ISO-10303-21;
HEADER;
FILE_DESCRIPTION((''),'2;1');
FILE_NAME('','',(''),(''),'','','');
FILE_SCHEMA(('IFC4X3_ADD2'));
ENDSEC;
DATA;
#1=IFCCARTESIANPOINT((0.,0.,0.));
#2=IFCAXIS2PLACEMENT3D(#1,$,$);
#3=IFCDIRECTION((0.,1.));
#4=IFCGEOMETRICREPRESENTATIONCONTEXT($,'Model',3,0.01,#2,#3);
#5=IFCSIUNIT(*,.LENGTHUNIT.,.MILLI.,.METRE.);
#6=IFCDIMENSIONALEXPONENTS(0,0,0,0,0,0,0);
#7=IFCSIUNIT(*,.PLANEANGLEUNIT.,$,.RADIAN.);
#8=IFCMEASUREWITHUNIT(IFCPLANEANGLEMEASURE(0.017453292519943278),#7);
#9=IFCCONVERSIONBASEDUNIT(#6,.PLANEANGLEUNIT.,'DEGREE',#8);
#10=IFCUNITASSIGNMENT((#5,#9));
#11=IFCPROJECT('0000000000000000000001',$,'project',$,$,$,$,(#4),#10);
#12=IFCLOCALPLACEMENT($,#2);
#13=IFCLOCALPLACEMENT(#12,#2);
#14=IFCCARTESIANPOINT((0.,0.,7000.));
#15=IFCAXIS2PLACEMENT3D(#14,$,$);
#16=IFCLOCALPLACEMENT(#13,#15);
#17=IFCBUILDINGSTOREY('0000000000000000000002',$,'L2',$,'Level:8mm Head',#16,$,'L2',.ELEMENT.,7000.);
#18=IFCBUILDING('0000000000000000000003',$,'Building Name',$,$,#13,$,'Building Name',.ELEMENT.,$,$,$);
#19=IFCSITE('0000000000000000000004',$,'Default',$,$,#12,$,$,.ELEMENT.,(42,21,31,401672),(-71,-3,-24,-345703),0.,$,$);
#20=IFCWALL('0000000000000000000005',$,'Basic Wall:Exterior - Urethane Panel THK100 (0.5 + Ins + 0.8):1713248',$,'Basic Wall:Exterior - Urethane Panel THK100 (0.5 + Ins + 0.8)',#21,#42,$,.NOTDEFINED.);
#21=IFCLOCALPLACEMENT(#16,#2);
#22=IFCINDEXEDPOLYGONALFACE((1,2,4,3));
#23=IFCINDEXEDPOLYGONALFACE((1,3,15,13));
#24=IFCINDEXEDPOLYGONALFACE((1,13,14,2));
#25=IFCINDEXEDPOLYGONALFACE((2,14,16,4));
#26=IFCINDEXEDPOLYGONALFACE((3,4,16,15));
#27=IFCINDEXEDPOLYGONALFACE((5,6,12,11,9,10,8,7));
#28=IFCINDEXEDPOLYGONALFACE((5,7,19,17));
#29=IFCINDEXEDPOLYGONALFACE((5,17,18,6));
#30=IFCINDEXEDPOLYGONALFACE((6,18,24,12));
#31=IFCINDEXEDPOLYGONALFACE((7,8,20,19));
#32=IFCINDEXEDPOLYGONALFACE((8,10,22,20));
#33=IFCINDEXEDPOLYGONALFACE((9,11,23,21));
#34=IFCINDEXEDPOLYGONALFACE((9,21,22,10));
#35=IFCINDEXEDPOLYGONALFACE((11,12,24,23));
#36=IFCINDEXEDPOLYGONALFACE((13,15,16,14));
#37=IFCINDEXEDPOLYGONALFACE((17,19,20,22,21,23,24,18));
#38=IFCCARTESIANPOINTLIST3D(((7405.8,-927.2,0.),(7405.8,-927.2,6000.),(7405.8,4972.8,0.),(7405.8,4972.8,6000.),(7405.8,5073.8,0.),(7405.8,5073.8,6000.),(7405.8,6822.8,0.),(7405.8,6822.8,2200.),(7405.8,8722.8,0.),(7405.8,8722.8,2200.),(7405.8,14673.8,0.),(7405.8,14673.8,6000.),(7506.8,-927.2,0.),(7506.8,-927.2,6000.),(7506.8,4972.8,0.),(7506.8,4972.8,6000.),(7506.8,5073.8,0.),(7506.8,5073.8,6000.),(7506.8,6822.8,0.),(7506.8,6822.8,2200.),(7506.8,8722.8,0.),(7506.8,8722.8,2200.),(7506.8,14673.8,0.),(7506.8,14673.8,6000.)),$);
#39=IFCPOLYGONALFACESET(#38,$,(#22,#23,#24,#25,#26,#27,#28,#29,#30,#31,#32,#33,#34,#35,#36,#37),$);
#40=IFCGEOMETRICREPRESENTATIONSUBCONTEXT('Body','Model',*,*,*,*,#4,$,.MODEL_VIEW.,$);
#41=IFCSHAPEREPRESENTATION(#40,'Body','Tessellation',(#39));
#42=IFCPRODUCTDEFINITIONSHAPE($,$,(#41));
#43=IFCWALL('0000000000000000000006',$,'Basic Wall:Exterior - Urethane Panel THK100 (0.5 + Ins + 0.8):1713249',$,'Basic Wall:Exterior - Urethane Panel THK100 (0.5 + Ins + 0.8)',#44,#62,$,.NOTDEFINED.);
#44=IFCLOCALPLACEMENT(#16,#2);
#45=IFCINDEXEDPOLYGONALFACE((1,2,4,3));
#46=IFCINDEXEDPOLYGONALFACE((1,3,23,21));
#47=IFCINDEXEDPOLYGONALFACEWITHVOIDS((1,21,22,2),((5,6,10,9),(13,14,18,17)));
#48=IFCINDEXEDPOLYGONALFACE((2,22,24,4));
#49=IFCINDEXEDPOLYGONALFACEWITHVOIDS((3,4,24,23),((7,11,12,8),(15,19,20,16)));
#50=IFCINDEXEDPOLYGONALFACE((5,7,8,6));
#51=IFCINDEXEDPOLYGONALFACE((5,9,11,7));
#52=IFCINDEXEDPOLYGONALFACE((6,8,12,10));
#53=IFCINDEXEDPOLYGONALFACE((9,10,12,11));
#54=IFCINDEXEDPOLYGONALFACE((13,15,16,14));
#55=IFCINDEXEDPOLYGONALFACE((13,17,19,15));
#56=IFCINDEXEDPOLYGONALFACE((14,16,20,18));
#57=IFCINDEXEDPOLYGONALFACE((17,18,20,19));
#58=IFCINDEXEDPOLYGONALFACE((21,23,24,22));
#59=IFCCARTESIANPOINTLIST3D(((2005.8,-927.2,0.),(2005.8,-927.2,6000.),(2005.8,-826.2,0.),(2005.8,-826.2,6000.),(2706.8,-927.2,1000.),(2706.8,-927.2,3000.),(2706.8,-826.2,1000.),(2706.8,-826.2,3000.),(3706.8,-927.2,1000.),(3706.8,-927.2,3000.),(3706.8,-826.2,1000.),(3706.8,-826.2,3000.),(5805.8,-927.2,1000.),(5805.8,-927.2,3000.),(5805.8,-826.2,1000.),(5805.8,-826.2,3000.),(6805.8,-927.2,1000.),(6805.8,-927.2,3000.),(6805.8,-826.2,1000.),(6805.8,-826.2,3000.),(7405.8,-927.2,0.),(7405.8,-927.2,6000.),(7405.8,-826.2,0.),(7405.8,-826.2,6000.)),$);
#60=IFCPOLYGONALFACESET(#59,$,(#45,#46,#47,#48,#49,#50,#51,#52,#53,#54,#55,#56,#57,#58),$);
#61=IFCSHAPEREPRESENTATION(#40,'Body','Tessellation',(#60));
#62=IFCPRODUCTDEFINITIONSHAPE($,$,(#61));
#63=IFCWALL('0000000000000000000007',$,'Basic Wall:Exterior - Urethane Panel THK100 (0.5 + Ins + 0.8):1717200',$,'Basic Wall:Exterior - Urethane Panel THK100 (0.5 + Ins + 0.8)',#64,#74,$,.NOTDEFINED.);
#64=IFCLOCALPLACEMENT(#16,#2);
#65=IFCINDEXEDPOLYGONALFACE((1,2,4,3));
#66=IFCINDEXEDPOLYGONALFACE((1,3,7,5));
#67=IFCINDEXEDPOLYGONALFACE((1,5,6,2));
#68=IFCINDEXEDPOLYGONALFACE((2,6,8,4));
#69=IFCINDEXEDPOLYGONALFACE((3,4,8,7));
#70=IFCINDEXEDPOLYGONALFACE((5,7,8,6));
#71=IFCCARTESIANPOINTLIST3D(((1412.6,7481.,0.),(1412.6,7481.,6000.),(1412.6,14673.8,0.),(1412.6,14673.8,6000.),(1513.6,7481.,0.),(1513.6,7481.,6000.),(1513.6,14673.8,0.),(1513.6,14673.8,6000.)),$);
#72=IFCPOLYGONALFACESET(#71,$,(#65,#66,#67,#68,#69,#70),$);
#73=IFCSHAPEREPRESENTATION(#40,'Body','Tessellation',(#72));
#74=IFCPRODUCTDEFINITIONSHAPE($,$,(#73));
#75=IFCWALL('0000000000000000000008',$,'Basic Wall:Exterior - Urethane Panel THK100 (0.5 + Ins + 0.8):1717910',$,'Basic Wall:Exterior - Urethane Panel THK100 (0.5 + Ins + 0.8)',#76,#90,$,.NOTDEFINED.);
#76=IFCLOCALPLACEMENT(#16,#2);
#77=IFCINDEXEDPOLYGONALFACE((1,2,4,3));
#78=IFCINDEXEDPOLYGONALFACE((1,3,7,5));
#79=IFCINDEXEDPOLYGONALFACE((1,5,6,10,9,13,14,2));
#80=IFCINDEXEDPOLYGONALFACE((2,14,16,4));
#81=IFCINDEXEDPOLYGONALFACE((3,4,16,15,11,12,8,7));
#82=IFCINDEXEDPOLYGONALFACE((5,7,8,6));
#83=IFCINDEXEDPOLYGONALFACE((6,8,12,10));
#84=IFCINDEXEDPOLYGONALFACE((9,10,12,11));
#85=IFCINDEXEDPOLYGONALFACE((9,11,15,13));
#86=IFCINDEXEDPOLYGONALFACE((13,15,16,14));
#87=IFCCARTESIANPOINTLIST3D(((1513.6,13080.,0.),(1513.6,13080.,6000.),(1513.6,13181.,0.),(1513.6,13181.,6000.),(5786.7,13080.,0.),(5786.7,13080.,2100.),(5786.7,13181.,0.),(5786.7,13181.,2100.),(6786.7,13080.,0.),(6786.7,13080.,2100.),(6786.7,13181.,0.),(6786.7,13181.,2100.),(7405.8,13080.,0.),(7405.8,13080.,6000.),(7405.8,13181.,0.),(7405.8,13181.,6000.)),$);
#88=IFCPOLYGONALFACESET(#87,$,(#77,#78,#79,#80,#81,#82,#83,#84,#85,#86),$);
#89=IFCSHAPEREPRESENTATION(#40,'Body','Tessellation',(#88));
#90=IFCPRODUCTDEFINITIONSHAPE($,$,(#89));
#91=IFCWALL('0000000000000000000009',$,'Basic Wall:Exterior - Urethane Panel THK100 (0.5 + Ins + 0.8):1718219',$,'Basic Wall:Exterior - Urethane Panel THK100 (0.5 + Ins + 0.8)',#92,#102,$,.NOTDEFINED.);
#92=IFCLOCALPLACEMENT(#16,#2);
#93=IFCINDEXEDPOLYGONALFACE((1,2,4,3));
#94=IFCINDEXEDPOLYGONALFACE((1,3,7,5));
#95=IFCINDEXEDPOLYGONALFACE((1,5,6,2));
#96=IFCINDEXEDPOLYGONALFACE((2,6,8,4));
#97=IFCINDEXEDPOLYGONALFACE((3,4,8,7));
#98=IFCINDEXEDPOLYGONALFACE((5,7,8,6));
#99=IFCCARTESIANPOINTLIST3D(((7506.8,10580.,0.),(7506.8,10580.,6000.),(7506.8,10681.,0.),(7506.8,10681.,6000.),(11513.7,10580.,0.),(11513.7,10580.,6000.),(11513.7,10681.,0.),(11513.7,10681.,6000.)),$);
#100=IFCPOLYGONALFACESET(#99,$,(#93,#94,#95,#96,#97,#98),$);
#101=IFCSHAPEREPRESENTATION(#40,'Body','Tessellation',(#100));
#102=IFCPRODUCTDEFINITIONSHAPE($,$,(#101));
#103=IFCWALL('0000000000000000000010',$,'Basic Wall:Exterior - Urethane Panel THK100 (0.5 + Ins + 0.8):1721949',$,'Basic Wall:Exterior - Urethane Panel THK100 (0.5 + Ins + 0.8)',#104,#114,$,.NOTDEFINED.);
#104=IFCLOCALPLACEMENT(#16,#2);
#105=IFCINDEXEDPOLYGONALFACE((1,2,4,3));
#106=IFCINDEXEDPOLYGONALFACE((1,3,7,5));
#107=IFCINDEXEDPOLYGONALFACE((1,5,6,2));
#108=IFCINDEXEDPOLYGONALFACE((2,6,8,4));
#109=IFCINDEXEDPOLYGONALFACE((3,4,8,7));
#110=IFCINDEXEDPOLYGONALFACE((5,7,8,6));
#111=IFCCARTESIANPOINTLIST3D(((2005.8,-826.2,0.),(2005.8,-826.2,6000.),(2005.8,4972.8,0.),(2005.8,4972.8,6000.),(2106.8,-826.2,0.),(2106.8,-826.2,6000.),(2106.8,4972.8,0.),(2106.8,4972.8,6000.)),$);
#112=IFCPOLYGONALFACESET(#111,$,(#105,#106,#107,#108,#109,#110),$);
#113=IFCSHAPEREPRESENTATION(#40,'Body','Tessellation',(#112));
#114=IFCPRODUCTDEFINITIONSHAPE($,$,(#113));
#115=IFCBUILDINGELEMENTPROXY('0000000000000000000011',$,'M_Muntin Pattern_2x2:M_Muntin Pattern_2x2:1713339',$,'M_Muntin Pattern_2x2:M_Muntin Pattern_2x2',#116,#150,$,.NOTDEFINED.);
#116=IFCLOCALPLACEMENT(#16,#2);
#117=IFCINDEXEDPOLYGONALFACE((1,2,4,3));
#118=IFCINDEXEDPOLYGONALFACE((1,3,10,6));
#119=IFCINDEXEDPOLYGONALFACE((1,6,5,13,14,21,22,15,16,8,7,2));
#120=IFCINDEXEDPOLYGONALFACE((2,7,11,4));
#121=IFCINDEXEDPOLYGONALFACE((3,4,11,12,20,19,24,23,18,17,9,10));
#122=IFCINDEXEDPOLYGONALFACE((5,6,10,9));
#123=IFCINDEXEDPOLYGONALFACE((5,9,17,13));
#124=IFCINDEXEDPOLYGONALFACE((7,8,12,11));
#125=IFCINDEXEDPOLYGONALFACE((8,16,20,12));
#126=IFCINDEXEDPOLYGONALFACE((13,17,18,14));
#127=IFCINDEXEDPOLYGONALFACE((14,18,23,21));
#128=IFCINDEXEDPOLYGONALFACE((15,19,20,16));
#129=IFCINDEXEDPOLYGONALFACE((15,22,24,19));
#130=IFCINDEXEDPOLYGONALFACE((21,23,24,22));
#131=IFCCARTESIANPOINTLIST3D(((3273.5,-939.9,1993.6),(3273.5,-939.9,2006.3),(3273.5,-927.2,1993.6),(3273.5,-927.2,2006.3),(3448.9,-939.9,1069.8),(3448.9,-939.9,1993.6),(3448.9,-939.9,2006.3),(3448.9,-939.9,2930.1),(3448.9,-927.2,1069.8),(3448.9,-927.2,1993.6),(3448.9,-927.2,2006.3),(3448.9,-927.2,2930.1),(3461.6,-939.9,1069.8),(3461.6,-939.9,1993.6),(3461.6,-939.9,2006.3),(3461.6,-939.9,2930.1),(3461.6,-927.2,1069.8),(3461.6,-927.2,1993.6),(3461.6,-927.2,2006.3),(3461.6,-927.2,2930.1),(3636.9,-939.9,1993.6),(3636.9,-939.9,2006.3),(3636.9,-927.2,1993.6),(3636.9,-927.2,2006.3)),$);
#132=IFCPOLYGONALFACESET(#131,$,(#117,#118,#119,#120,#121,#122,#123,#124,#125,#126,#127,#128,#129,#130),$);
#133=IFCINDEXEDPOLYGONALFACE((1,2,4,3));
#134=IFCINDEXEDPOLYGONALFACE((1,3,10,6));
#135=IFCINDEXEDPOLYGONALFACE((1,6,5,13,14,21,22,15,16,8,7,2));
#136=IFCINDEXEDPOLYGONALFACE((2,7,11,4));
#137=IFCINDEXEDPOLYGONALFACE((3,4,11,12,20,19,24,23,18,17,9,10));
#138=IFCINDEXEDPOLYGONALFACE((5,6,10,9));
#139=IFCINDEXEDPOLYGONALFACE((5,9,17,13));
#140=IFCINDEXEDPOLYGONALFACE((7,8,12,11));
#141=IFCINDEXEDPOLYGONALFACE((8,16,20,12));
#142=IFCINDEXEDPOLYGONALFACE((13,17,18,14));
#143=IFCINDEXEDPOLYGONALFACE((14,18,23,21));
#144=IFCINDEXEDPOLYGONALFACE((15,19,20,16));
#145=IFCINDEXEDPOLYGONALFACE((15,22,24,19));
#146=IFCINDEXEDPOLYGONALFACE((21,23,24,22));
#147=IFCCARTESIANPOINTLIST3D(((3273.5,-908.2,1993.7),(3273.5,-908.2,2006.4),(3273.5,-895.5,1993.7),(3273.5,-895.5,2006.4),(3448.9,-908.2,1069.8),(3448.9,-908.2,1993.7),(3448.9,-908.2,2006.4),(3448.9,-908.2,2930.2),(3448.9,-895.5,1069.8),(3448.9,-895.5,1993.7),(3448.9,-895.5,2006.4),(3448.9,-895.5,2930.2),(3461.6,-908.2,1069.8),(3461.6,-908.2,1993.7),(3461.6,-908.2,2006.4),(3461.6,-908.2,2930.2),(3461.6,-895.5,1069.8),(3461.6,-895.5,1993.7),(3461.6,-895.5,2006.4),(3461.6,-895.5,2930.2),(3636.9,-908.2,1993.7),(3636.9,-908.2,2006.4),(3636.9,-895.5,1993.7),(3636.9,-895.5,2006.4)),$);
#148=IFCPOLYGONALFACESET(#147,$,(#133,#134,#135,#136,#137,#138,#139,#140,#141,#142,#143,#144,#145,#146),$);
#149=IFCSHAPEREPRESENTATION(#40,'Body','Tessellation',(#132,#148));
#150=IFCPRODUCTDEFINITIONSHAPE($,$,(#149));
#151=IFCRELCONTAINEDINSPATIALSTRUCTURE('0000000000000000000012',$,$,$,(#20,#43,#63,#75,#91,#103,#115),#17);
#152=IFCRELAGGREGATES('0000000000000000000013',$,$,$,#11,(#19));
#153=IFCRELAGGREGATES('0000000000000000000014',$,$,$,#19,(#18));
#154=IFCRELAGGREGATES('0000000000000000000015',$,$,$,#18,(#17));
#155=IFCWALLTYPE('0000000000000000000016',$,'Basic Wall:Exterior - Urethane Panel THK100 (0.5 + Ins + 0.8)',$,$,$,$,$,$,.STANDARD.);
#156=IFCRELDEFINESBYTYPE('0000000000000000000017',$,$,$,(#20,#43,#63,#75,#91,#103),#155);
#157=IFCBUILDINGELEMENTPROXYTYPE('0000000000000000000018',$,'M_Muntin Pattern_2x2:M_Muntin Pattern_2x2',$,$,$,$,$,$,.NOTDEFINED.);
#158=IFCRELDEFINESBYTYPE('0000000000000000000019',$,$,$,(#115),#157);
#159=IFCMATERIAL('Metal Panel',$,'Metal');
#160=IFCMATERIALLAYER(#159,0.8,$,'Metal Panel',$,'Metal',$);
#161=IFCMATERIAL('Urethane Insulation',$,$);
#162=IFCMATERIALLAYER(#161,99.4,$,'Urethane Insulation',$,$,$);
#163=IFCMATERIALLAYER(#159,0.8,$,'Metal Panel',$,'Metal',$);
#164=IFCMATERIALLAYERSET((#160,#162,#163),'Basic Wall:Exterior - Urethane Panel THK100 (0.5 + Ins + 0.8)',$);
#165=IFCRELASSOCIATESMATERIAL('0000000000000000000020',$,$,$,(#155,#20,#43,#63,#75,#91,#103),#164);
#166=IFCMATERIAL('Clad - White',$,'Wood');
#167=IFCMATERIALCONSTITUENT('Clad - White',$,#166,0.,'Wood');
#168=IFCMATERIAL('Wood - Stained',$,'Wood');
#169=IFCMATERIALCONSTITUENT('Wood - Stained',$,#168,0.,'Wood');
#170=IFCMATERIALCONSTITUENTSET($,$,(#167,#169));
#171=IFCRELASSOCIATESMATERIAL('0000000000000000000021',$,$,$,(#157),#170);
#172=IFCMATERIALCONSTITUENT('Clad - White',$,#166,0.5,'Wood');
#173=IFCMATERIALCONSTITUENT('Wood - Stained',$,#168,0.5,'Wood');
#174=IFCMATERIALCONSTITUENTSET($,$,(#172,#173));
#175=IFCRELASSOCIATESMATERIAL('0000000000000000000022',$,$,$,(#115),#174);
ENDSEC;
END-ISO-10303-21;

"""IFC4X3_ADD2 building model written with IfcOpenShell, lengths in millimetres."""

from ifc_helpers import new_model, entity, si_unit, converted_unit, direction, frame, frame_2d, origin, place, context, subcontext, project, spatial, polyline, rectangle, outline, extrude, source, transform, mapped, material, layer, layer_set, constituent, constituent_set, type_object, type_shapes, element, save


model = new_model("IFC4X3_ADD2")

# Units and contexts
model_context = context("Model", 3, precision=0.01, world=origin(), true_north=direction((0.0, 1.0)))
body_context = subcontext(model_context, "Body", "Model", "MODEL_VIEW")
ifc_project = project(units=[si_unit("LENGTHUNIT", "METRE", prefix="MILLI"), converted_unit("PLANEANGLEUNIT", "DEGREE", entity("IfcPlaneAngleMeasure", 0.017453292519943278), si_unit("PLANEANGLEUNIT", "RADIAN"), dimensions=[0, 0, 0, 0, 0, 0, 0])], contexts=[model_context])

# Site, building, storey
site_placement = place(None, origin())
site = spatial("IfcSite", under=ifc_project, at=site_placement, Name="Default", CompositionType="ELEMENT", RefLatitude=(42, 21, 31, 401672), RefLongitude=(-71, -3, -24, -345703), RefElevation=0.0)
building_placement = place(site_placement, origin())
building = spatial("IfcBuilding", under=site, at=building_placement, Name="Building Name", LongName="Building Name", CompositionType="ELEMENT")
storey_placement = place(building_placement, frame((0.0, 0.0, 7000.0)))
storey = spatial("IfcBuildingStorey", under=building, at=storey_placement, Name="L2", ObjectType="Level:8mm Head", LongName="L2", CompositionType="ELEMENT", Elevation=7000.0)

# Walls, openings
ifc_material_1 = material(Name="Metal Panel", Category="Metal")
ifc_layer_1 = layer(ifc_material_1, 0.8, Name="Metal Panel", Category="Metal")
ifc_material_2 = material(Name="Urethane Insulation")
ifc_layer_2 = layer(ifc_material_2, 99.4, Name="Urethane Insulation")
ifc_layer_3 = layer(ifc_material_1, 0.8, Name="Metal Panel", Category="Metal")
ifc_layer_set_1 = layer_set([ifc_layer_1, ifc_layer_2, ifc_layer_3], Name="Basic Wall:Exterior - Urethane Panel THK100 (0.5 + Ins + 0.8)")
wall_type = type_object("IfcWallType", Name="Basic Wall:Exterior - Urethane Panel THK100 (0.5 + Ins + 0.8)", PredefinedType="STANDARD", material=ifc_layer_set_1)
wall_1_placement = place(storey_placement, frame((7456.3, 14673.8, 0.0), z_axis=(0.0, 0.0, 1.0), x_axis=(0.0, -1.0, 0.0)))
wall_1 = element("IfcWall", 1, at=wall_1_placement, inside=storey, type_object=wall_type, material=ifc_layer_set_1, Name="Basic Wall:Exterior - Urethane Panel THK100 (0.5 + Ins + 0.8):1713248", ObjectType="Basic Wall:Exterior - Urethane Panel THK100 (0.5 + Ins + 0.8)", PredefinedType="NOTDEFINED", context=body_context, shape_type="SweptSolid", body=[
    extrude(rectangle(XDim=15601.0, YDim=101.0, at=frame_2d((7800.5, 0.0), x_axis=(-1.0, 0.0))), origin(), (0.0, 0.0, 1.0), 6000.0),
])
opening_1_placement = place(storey_placement, frame((7456.3, 14673.8, 0.0), z_axis=(0.0, 0.0, 1.0), x_axis=(0.0, -1.0, 0.0)))
element("IfcOpeningElement", 2, at=opening_1_placement, cuts=wall_1, PredefinedType="OPENING", context=body_context, shape_type="SweptSolid", body=[
    extrude(rectangle(XDim=6000.0, YDim=101.0, at=frame_2d((0.0, 0.0), x_axis=(1.0, 0.0))), frame((9701.0, 0.0, 3000.0), z_axis=(-1.0, 0.0, 0.0), x_axis=(0.0, 0.0, 1.0)), (0.0, 0.0, 1.0), 101.0),
])
opening_2_placement = place(wall_1_placement, frame((5951.0, -50.5, 0.0)))
element("IfcOpeningElement", 3, at=opening_2_placement, cuts=wall_1, PredefinedType="OPENING", context=body_context, shape_type="SweptSolid", body=[
    extrude(rectangle(XDim=2200.0, YDim=1900.0, at=frame_2d((1100.0, 950.0), x_axis=(1.0, 0.0))), frame((0.0, 0.0, 0.0), z_axis=(0.0, 1.0, 0.0), x_axis=(0.0, 0.0, 1.0)), (0.0, 0.0, 1.0), 101.0),
])
wall_2_placement = place(storey_placement, frame((2005.8, -876.7, 0.0)))
wall_2 = element("IfcWall", 4, at=wall_2_placement, inside=storey, type_object=wall_type, material=ifc_layer_set_1, Name="Basic Wall:Exterior - Urethane Panel THK100 (0.5 + Ins + 0.8):1713249", ObjectType="Basic Wall:Exterior - Urethane Panel THK100 (0.5 + Ins + 0.8)", PredefinedType="NOTDEFINED", context=body_context, shape_type="SweptSolid", body=[
    extrude(rectangle(XDim=5400.0, YDim=101.0, at=frame_2d((2700.0, 0.0), x_axis=(-1.0, 0.0))), origin(), (0.0, 0.0, 1.0), 6000.0),
])
opening_3_placement = place(wall_2_placement, frame((1701.0, 50.5, 1000.0)))
element("IfcOpeningElement", 5, at=opening_3_placement, cuts=wall_2, PredefinedType="OPENING", context=body_context, shape_type="SweptSolid", body=[
    extrude(rectangle(XDim=2000.0, YDim=1000.0, at=frame_2d((1000.0, 500.0), x_axis=(-1.0, 0.0))), frame((0.0, 0.0, 0.0), z_axis=(0.0, -1.0, 0.0), x_axis=(0.0, 0.0, 1.0)), (0.0, 0.0, 1.0), 101.0),
])
opening_4_placement = place(wall_2_placement, frame((4800.0, 50.5, 1000.0)))
element("IfcOpeningElement", 6, at=opening_4_placement, cuts=wall_2, PredefinedType="OPENING", context=body_context, shape_type="SweptSolid", body=[
    extrude(rectangle(XDim=2000.0, YDim=1000.0, at=frame_2d((1000.0, 500.0), x_axis=(-1.0, 0.0))), frame((0.0, 0.0, 0.0), z_axis=(0.0, -1.0, 0.0), x_axis=(0.0, 0.0, 1.0)), (0.0, 0.0, 1.0), 101.0),
])

# Wall
wall_3_placement = place(storey_placement, frame((1463.1, 14673.8, 0.0), z_axis=(0.0, 0.0, 1.0), x_axis=(0.0, -1.0, 0.0)))
element("IfcWall", 7, at=wall_3_placement, inside=storey, type_object=wall_type, material=ifc_layer_set_1, Name="Basic Wall:Exterior - Urethane Panel THK100 (0.5 + Ins + 0.8):1717200", ObjectType="Basic Wall:Exterior - Urethane Panel THK100 (0.5 + Ins + 0.8)", PredefinedType="NOTDEFINED", context=body_context, shape_type="SweptSolid", body=[
    extrude(rectangle(XDim=7192.8, YDim=101.0, at=frame_2d((3596.4, 0.0), x_axis=(-1.0, 0.0))), origin(), (0.0, 0.0, 1.0), 6000.0),
])

# Wall, opening
wall_4_placement = place(storey_placement, frame((1513.6, 13130.5, 0.0)))
wall_4 = element("IfcWall", 8, at=wall_4_placement, inside=storey, type_object=wall_type, material=ifc_layer_set_1, Name="Basic Wall:Exterior - Urethane Panel THK100 (0.5 + Ins + 0.8):1717910", ObjectType="Basic Wall:Exterior - Urethane Panel THK100 (0.5 + Ins + 0.8)", PredefinedType="NOTDEFINED", context=body_context, shape_type="SweptSolid", body=[
    extrude(rectangle(XDim=5892.2, YDim=101.0, at=frame_2d((2946.1, 0.0), x_axis=(1.0, 0.0))), origin(), (0.0, 0.0, 1.0), 6000.0),
])
opening_5_placement = place(wall_4_placement, frame((4273.2, -50.5, 0.0)))
element("IfcOpeningElement", 9, at=opening_5_placement, cuts=wall_4, PredefinedType="OPENING", context=body_context, shape_type="SweptSolid", body=[
    extrude(rectangle(XDim=2100.0, YDim=1000.0, at=frame_2d((1050.0, 500.0), x_axis=(1.0, 0.0))), frame((0.0, 0.0, 0.0), z_axis=(0.0, 1.0, 0.0), x_axis=(0.0, 0.0, 1.0)), (0.0, 0.0, 1.0), 101.0),
])

# Walls
wall_5_placement = place(storey_placement, frame((7506.8, 10630.5, 0.0)))
element("IfcWall", 10, at=wall_5_placement, inside=storey, type_object=wall_type, material=ifc_layer_set_1, Name="Basic Wall:Exterior - Urethane Panel THK100 (0.5 + Ins + 0.8):1718219", ObjectType="Basic Wall:Exterior - Urethane Panel THK100 (0.5 + Ins + 0.8)", PredefinedType="NOTDEFINED", context=body_context, shape_type="SweptSolid", body=[
    extrude(rectangle(XDim=4006.9, YDim=101.0, at=frame_2d((2003.4, 0.0), x_axis=(-1.0, 0.0))), origin(), (0.0, 0.0, 1.0), 6000.0),
])
wall_6_placement = place(storey_placement, frame((2056.3, -826.2, 0.0), z_axis=(0.0, 0.0, 1.0), x_axis=(0.0, 1.0, 0.0)))
element("IfcWall", 11, at=wall_6_placement, inside=storey, type_object=wall_type, material=ifc_layer_set_1, Name="Basic Wall:Exterior - Urethane Panel THK100 (0.5 + Ins + 0.8):1721949", ObjectType="Basic Wall:Exterior - Urethane Panel THK100 (0.5 + Ins + 0.8)", PredefinedType="NOTDEFINED", context=body_context, shape_type="SweptSolid", body=[
    extrude(rectangle(XDim=5799.0, YDim=101.0, at=frame_2d((2899.5, 0.0), x_axis=(-1.0, 0.0))), origin(), (0.0, 0.0, 1.0), 6000.0),
])

# Building element proxy
ifc_material_3 = material(Name="Clad - White", Category="Wood")
ifc_constituent_1 = constituent(ifc_material_3, Name="Clad - White", Category="Wood", fraction=0.5)
ifc_material_4 = material(Name="Wood - Stained", Category="Wood")
ifc_constituent_2 = constituent(ifc_material_4, Name="Wood - Stained", Category="Wood", fraction=0.5)
ifc_constituent_set_1 = constituent_set(constituents=[ifc_constituent_1, ifc_constituent_2])
ifc_constituent_3 = constituent(ifc_material_3, Name="Clad - White", Category="Wood", fraction=0.0)
ifc_constituent_4 = constituent(ifc_material_4, Name="Wood - Stained", Category="Wood", fraction=0.0)
ifc_constituent_set_2 = constituent_set(constituents=[ifc_constituent_3, ifc_constituent_4])
building_element_proxy_type_1 = type_object("IfcBuildingElementProxyType", Name="M_Muntin Pattern_2x2:M_Muntin Pattern_2x2", PredefinedType="NOTDEFINED", material=ifc_constituent_set_2)
shared_shape_1 = source(origin(), body_context, "Body", "SweptSolid", [
    extrude(outline(polyline([(6.4, -6.4), (930.1, -6.4), (930.1, 6.3), (6.4, 6.3), (6.4, 181.7), (-6.3, 181.7), (-6.3, 6.3), (-930.2, 6.3), (-930.2, -6.4), (-6.3, -6.4), (-6.3, -181.7), (6.4, -181.7), (6.4, -6.4)])), frame((0.0, 9.5, 930.1), z_axis=(0.0, 1.0, 0.0), x_axis=(0.0, 0.0, 1.0)), (0.0, 0.0, 1.0), 12.7),
    extrude(outline(polyline([(6.4, -6.4), (930.2, -6.4), (930.2, 6.3), (6.4, 6.3), (6.4, 181.7), (-6.3, 181.7), (-6.3, 6.3), (-930.2, 6.3), (-930.2, -6.4), (-6.3, -6.4), (-6.3, -181.7), (6.4, -181.7), (6.4, -6.4)])), frame((0.0, -22.2, 930.2), z_axis=(0.0, 1.0, 0.0), x_axis=(0.0, 0.0, 1.0)), (0.0, 0.0, 1.0), 12.7),
])
type_shapes(building_element_proxy_type_1, [shared_shape_1])
proxy_1_placement = place(storey_placement, frame((3455.2, -917.7, 1069.8), z_axis=(0.0, 0.0, 1.0), x_axis=(-1.0, 0.0, 0.0)))
element("IfcBuildingElementProxy", 12, at=proxy_1_placement, inside=storey, type_object=building_element_proxy_type_1, material=ifc_constituent_set_1, Name="M_Muntin Pattern_2x2:M_Muntin Pattern_2x2:1713339", ObjectType="M_Muntin Pattern_2x2:M_Muntin Pattern_2x2", PredefinedType="NOTDEFINED", context=body_context, shape_type="MappedRepresentation", body=[
    mapped(shared_shape_1, transform((0.0, 0.0, 0.0), scale=1.0)),
])

save(model, "model.ifc")
